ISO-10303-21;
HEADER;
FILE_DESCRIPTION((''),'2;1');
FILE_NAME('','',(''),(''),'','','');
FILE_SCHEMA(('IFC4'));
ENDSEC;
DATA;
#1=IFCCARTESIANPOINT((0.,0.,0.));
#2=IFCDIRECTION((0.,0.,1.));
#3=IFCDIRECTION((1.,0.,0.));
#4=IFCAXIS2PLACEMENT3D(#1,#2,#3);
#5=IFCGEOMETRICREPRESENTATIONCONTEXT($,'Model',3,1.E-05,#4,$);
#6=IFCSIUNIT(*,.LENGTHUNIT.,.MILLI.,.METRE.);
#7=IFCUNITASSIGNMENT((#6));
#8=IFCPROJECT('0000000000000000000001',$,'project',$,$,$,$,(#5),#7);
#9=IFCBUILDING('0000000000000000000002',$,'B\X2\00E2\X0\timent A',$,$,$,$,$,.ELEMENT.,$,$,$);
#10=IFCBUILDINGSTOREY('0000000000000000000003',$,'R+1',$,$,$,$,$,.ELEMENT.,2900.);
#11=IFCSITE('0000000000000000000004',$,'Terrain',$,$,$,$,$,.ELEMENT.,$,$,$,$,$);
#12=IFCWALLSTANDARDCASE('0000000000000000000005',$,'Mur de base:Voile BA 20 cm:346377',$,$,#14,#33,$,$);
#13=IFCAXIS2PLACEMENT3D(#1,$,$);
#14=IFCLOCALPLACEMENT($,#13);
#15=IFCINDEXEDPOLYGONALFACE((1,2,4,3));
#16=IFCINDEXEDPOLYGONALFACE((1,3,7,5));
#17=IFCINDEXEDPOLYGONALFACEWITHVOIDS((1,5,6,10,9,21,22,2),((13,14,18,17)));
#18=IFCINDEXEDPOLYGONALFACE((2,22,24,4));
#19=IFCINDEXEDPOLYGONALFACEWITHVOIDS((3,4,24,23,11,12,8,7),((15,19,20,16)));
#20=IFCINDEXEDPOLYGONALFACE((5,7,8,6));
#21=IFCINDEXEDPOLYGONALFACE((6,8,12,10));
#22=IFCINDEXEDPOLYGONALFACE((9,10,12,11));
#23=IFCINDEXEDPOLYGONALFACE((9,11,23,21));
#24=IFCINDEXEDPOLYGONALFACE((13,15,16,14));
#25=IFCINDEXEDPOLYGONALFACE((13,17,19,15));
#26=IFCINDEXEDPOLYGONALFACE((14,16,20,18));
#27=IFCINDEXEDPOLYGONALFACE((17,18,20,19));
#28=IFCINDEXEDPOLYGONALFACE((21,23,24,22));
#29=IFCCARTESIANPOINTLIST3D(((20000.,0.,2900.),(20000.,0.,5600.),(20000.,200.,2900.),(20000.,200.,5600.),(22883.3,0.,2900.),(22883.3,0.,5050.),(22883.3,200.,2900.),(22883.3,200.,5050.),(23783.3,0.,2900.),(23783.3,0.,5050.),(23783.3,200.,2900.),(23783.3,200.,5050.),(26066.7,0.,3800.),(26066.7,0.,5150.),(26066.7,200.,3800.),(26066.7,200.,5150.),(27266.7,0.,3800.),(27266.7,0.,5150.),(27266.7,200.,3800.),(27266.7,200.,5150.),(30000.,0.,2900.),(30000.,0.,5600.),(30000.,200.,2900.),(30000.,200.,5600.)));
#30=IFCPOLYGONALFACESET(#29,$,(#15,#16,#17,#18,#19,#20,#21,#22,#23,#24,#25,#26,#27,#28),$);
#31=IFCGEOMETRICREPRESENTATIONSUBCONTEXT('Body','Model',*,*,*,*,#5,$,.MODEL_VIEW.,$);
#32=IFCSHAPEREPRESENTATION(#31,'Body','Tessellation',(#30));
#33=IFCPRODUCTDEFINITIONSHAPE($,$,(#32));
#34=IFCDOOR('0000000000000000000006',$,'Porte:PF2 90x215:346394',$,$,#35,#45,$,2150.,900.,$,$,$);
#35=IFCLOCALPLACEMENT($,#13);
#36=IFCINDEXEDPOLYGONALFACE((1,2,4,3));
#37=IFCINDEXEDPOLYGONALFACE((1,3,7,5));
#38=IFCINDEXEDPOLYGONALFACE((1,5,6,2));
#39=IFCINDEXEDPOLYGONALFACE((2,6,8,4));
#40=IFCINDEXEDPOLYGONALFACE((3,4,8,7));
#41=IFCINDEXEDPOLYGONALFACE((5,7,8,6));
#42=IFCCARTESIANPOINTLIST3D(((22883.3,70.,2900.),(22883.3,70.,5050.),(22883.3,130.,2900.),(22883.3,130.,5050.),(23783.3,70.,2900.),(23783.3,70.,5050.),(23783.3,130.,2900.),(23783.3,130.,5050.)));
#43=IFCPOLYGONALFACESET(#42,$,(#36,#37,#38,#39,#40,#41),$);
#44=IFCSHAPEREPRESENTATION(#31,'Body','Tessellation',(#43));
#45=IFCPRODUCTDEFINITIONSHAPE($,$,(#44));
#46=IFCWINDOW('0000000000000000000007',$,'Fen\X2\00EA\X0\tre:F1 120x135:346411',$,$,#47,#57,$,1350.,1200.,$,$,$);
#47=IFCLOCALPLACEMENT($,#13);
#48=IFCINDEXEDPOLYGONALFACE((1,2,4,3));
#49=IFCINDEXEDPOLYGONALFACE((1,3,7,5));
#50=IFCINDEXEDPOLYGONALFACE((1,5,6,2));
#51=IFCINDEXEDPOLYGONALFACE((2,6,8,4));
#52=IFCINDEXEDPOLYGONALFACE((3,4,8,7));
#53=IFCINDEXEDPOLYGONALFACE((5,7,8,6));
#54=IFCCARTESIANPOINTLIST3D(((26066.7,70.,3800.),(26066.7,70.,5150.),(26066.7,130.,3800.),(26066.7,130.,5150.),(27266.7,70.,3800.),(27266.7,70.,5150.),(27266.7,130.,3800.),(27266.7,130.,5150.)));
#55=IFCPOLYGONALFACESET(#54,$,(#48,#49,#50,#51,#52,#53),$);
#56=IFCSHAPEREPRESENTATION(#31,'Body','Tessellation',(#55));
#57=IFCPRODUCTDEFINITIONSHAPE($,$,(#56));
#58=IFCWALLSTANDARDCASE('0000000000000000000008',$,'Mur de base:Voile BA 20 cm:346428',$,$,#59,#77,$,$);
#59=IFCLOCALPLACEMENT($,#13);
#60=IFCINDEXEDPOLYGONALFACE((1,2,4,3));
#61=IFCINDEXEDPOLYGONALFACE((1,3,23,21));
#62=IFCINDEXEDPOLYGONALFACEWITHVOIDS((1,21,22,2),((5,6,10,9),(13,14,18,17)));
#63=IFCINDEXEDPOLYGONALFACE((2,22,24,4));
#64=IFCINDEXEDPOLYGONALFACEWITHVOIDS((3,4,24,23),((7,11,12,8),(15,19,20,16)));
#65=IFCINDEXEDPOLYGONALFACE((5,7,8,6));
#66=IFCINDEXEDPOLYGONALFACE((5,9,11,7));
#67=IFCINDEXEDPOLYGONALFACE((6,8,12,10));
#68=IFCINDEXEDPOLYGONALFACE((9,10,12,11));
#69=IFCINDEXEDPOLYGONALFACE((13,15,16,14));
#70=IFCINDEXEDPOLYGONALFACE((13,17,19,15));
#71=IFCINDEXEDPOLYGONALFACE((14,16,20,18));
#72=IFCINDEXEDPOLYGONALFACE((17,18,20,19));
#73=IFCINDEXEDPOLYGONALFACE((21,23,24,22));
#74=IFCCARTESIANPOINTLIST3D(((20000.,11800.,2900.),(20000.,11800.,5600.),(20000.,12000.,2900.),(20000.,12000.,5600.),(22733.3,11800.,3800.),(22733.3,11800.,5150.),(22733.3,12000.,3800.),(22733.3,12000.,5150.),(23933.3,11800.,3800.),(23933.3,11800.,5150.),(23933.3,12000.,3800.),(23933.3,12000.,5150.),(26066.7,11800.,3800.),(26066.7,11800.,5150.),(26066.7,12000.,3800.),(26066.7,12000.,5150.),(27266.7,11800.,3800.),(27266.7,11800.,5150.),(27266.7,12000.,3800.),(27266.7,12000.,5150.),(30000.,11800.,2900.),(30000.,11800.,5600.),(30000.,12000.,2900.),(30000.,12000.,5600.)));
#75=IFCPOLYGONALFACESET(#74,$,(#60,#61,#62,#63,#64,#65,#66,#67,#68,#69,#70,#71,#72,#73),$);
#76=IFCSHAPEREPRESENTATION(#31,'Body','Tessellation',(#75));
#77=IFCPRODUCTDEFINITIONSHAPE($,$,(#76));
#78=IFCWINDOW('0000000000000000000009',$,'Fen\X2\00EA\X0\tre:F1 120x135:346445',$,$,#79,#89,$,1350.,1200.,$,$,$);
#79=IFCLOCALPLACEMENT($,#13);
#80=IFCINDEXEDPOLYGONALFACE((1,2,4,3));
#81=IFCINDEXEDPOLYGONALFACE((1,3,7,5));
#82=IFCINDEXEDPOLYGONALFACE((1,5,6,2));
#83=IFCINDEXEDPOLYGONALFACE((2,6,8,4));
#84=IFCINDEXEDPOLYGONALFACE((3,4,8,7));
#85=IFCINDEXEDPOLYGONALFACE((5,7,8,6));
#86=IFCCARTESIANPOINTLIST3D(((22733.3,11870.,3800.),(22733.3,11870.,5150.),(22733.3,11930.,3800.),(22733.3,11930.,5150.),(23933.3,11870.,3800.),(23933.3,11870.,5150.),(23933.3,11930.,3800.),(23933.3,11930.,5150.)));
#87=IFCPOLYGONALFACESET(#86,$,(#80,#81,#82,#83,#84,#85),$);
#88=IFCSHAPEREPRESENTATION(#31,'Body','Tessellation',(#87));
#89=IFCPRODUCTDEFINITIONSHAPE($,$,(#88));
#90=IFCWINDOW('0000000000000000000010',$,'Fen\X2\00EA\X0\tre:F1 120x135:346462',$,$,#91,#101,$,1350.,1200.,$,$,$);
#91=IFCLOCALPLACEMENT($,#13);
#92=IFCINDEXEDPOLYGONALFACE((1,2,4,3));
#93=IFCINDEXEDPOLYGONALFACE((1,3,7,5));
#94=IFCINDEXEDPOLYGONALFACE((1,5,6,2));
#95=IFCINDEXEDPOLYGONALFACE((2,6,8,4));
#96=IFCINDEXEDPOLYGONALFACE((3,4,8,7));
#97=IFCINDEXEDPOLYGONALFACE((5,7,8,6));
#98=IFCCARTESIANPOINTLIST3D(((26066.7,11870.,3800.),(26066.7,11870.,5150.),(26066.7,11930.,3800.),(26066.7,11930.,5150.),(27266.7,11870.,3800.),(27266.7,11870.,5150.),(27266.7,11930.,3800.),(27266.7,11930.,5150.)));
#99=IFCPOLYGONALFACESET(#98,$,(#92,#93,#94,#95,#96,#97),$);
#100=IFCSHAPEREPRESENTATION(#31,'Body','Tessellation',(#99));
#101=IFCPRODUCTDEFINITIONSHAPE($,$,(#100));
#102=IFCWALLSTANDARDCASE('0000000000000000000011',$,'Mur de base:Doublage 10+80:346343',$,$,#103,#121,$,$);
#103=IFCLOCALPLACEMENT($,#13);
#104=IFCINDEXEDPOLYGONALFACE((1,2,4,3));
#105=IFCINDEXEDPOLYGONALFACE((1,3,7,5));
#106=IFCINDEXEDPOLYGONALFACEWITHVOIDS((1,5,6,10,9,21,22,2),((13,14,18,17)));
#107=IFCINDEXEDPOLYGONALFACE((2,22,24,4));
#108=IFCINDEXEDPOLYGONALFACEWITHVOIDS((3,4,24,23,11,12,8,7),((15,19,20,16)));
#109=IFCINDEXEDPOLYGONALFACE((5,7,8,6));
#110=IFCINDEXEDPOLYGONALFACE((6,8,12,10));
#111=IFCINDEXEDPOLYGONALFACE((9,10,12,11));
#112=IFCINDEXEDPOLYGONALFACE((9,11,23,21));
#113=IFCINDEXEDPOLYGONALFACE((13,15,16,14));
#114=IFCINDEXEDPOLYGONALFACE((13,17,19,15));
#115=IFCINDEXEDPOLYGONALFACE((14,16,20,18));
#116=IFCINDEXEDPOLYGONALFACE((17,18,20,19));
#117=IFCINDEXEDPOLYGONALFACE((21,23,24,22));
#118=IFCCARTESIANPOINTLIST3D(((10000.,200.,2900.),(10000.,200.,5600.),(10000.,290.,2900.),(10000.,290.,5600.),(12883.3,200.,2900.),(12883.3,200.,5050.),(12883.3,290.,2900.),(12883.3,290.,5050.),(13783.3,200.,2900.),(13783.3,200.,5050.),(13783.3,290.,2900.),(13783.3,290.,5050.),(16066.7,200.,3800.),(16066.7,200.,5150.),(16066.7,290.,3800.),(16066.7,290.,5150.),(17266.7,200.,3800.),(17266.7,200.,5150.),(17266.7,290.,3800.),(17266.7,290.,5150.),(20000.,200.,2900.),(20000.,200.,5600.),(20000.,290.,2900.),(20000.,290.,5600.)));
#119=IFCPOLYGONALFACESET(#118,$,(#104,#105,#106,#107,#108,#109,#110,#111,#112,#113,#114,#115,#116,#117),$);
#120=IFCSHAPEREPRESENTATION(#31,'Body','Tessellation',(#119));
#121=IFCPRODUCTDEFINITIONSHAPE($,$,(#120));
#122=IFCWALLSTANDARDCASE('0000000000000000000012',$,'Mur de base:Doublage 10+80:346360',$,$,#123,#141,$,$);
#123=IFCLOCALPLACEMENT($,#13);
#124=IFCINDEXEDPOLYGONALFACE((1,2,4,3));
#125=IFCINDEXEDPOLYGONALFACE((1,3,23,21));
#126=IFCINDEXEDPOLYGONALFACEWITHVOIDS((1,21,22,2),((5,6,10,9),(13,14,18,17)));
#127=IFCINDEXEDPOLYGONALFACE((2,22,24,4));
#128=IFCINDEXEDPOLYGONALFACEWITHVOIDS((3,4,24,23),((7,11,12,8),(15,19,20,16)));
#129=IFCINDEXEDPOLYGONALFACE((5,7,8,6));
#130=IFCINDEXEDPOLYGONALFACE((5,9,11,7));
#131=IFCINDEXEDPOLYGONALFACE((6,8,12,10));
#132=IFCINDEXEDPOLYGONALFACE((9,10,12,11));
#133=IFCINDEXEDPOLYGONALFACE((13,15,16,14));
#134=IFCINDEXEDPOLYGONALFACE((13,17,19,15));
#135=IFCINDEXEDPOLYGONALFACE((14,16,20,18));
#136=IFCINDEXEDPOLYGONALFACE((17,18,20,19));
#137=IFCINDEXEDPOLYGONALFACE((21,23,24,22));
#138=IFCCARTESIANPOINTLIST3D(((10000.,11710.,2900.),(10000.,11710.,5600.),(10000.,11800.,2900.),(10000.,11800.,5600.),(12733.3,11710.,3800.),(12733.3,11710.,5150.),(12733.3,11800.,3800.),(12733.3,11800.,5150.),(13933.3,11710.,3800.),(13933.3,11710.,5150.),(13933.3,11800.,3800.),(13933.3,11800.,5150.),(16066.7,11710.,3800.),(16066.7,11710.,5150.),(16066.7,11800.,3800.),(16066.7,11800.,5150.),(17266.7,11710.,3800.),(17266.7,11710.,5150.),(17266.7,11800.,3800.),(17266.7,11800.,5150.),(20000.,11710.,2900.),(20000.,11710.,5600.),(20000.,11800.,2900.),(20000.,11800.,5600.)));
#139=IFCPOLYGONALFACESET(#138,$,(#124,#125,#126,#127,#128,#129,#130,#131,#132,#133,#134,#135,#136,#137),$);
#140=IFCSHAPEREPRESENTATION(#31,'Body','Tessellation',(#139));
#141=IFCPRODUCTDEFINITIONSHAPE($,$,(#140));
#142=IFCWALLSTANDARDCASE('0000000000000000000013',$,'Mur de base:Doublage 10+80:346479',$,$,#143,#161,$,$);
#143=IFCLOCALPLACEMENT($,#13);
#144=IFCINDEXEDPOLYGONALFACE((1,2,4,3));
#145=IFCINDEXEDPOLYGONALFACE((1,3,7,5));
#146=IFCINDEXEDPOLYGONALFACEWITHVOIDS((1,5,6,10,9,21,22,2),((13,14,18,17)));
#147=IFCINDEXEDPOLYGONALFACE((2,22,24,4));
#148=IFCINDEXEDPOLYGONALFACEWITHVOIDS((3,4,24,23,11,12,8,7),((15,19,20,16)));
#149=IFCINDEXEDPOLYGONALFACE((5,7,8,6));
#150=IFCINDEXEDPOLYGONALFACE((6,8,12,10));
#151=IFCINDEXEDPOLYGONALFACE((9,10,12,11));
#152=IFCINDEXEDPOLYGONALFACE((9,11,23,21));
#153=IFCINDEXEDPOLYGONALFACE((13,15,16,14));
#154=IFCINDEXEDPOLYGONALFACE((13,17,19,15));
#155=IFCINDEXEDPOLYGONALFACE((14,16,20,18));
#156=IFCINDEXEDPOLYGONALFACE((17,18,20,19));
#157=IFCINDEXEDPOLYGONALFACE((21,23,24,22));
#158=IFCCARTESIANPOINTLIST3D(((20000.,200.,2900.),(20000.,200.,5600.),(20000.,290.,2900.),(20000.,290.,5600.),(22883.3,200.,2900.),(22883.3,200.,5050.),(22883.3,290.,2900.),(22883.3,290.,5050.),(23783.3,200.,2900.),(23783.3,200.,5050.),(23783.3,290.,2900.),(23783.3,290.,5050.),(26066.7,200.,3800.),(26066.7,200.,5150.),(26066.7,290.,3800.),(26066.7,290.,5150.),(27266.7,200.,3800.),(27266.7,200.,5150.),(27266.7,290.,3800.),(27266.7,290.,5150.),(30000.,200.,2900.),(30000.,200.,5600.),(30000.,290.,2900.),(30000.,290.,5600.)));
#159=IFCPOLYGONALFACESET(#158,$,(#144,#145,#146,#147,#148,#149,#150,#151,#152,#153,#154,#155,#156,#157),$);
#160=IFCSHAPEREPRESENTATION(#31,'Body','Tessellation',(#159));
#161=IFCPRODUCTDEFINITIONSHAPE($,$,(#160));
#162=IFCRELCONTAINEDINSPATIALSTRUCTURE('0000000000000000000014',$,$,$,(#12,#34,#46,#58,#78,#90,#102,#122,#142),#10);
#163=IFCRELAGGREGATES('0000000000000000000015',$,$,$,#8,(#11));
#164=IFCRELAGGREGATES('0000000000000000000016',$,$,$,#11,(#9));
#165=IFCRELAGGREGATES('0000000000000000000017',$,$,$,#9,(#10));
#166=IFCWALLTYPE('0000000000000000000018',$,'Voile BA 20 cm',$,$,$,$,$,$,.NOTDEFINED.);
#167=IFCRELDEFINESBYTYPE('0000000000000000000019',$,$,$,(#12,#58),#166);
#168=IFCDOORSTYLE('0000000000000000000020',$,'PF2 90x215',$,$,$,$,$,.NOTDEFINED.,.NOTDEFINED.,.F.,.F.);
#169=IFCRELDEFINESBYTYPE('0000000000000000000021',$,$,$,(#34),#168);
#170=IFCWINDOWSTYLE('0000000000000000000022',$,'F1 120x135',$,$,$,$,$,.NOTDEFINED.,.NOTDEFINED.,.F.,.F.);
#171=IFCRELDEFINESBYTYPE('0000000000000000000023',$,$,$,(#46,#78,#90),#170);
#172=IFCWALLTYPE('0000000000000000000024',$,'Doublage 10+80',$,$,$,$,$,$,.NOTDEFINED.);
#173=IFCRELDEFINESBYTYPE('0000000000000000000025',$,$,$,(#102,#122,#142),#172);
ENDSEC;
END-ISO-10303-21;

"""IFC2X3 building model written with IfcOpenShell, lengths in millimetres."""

from ifc_helpers import new_model, si_unit, frame, frame_2d, origin_with_axes, place, context, subcontext, project, spatial, rectangle, extrude, type_object, element, fill, save


model = new_model("IFC2X3")

# Units and contexts
model_context = context("Model", 3, precision=1e-05, world=origin_with_axes())
body_context = subcontext(model_context, "Body", "Model", "MODEL_VIEW")
ifc_project = project(units=[si_unit("LENGTHUNIT", "METRE", prefix="MILLI")], contexts=[model_context])

# Site, building, storey
site = spatial("IfcSite", under=ifc_project, Name="Terrain", CompositionType="ELEMENT")
building = spatial("IfcBuilding", under=site, Name="Bâtiment A", CompositionType="ELEMENT")
storey = spatial("IfcBuildingStorey", under=building, Name="R+1", CompositionType="ELEMENT", Elevation=2900.0)

# Wall, openings, door, window
wall_type_1 = type_object("IfcWallType", Name="Voile BA 20 cm", PredefinedType="NOTDEFINED")
wall_1_placement = place(None, origin_with_axes())
wall_1 = element("IfcWallStandardCase", 1, at=wall_1_placement, inside=storey, type_object=wall_type_1, Name="Mur de base:Voile BA 20 cm:346377", context=body_context, shape_type="SweptSolid", body=[
    extrude(rectangle(XDim=10000.0, YDim=200.0, at=frame_2d((25000.0, 100.0))), frame((0.0, 0.0, 2900.0), z_axis=(0.0, 0.0, 1.0), x_axis=(1.0, 0.0, 0.0)), (0.0, 0.0, 1.0), 2700.0),
])
opening_1_placement = place(None, origin_with_axes())
opening_1 = element("IfcOpeningElement", 2, at=opening_1_placement, cuts=wall_1, context=body_context, shape_type="SweptSolid", body=[
    extrude(rectangle(XDim=900.0, YDim=320.0, at=frame_2d((23333.3, 100.0))), frame((0.0, 0.0, 2900.0), z_axis=(0.0, 0.0, 1.0), x_axis=(1.0, 0.0, 0.0)), (0.0, 0.0, 1.0), 2150.0),
])
opening_2_placement = place(None, origin_with_axes())
opening_2 = element("IfcOpeningElement", 3, at=opening_2_placement, cuts=wall_1, context=body_context, shape_type="SweptSolid", body=[
    extrude(rectangle(XDim=1200.0, YDim=320.0, at=frame_2d((26666.7, 100.0))), frame((0.0, 0.0, 3800.0), z_axis=(0.0, 0.0, 1.0), x_axis=(1.0, 0.0, 0.0)), (0.0, 0.0, 1.0), 1350.0),
])
door_style = type_object("IfcDoorStyle", Name="PF2 90x215", ConstructionType="NOTDEFINED", OperationType="NOTDEFINED", ParameterTakesPrecedence=False, Sizeable=False)
door_placement = place(None, origin_with_axes())
door = element("IfcDoor", 4, at=door_placement, inside=storey, type_object=door_style, Name="Porte:PF2 90x215:346394", OverallHeight=2150.0, OverallWidth=900.0, context=body_context, shape_type="SweptSolid", body=[
    extrude(rectangle(XDim=900.0, YDim=60.0, at=frame_2d((23333.3, 100.0))), frame((0.0, 0.0, 2900.0), z_axis=(0.0, 0.0, 1.0), x_axis=(1.0, 0.0, 0.0)), (0.0, 0.0, 1.0), 2150.0),
])
fill(opening_1, door)
window_style = type_object("IfcWindowStyle", Name="F1 120x135", ConstructionType="NOTDEFINED", OperationType="NOTDEFINED", ParameterTakesPrecedence=False, Sizeable=False)
window_1_placement = place(None, origin_with_axes())
window_1 = element("IfcWindow", 5, at=window_1_placement, inside=storey, type_object=window_style, Name="Fenêtre:F1 120x135:346411", OverallHeight=1350.0, OverallWidth=1200.0, context=body_context, shape_type="SweptSolid", body=[
    extrude(rectangle(XDim=1200.0, YDim=60.0, at=frame_2d((26666.7, 100.0))), frame((0.0, 0.0, 3800.0), z_axis=(0.0, 0.0, 1.0), x_axis=(1.0, 0.0, 0.0)), (0.0, 0.0, 1.0), 1350.0),
])
fill(opening_2, window_1)

# Wall, openings, windows
wall_2_placement = place(None, origin_with_axes())
wall_2 = element("IfcWallStandardCase", 6, at=wall_2_placement, inside=storey, type_object=wall_type_1, Name="Mur de base:Voile BA 20 cm:346428", context=body_context, shape_type="SweptSolid", body=[
    extrude(rectangle(XDim=10000.0, YDim=200.0, at=frame_2d((25000.0, 11900.0))), frame((0.0, 0.0, 2900.0), z_axis=(0.0, 0.0, 1.0), x_axis=(1.0, 0.0, 0.0)), (0.0, 0.0, 1.0), 2700.0),
])
opening_3_placement = place(None, origin_with_axes())
opening_3 = element("IfcOpeningElement", 7, at=opening_3_placement, cuts=wall_2, context=body_context, shape_type="SweptSolid", body=[
    extrude(rectangle(XDim=1200.0, YDim=320.0, at=frame_2d((23333.3, 11900.0))), frame((0.0, 0.0, 3800.0), z_axis=(0.0, 0.0, 1.0), x_axis=(1.0, 0.0, 0.0)), (0.0, 0.0, 1.0), 1350.0),
])
opening_4_placement = place(None, origin_with_axes())
opening_4 = element("IfcOpeningElement", 8, at=opening_4_placement, cuts=wall_2, context=body_context, shape_type="SweptSolid", body=[
    extrude(rectangle(XDim=1200.0, YDim=320.0, at=frame_2d((26666.7, 11900.0))), frame((0.0, 0.0, 3800.0), z_axis=(0.0, 0.0, 1.0), x_axis=(1.0, 0.0, 0.0)), (0.0, 0.0, 1.0), 1350.0),
])
window_2_placement = place(None, origin_with_axes())
window_2 = element("IfcWindow", 9, at=window_2_placement, inside=storey, type_object=window_style, Name="Fenêtre:F1 120x135:346445", OverallHeight=1350.0, OverallWidth=1200.0, context=body_context, shape_type="SweptSolid", body=[
    extrude(rectangle(XDim=1200.0, YDim=60.0, at=frame_2d((23333.3, 11900.0))), frame((0.0, 0.0, 3800.0), z_axis=(0.0, 0.0, 1.0), x_axis=(1.0, 0.0, 0.0)), (0.0, 0.0, 1.0), 1350.0),
])
fill(opening_3, window_2)
window_3_placement = place(None, origin_with_axes())
window_3 = element("IfcWindow", 10, at=window_3_placement, inside=storey, type_object=window_style, Name="Fenêtre:F1 120x135:346462", OverallHeight=1350.0, OverallWidth=1200.0, context=body_context, shape_type="SweptSolid", body=[
    extrude(rectangle(XDim=1200.0, YDim=60.0, at=frame_2d((26666.7, 11900.0))), frame((0.0, 0.0, 3800.0), z_axis=(0.0, 0.0, 1.0), x_axis=(1.0, 0.0, 0.0)), (0.0, 0.0, 1.0), 1350.0),
])
fill(opening_4, window_3)

# Walls, openings
wall_type_2 = type_object("IfcWallType", Name="Doublage 10+80", PredefinedType="NOTDEFINED")
wall_3_placement = place(None, origin_with_axes())
wall_3 = element("IfcWallStandardCase", 11, at=wall_3_placement, inside=storey, type_object=wall_type_2, Name="Mur de base:Doublage 10+80:346343", context=body_context, shape_type="SweptSolid", body=[
    extrude(rectangle(XDim=10000.0, YDim=90.0, at=frame_2d((15000.0, 245.0))), frame((0.0, 0.0, 2900.0), z_axis=(0.0, 0.0, 1.0), x_axis=(1.0, 0.0, 0.0)), (0.0, 0.0, 1.0), 2700.0),
])
opening_5_placement = place(None, origin_with_axes())
element("IfcOpeningElement", 12, at=opening_5_placement, cuts=wall_3, context=body_context, shape_type="SweptSolid", body=[
    extrude(rectangle(XDim=900.0, YDim=210.0, at=frame_2d((13333.3, 245.0))), frame((0.0, 0.0, 2900.0), z_axis=(0.0, 0.0, 1.0), x_axis=(1.0, 0.0, 0.0)), (0.0, 0.0, 1.0), 2150.0),
])
opening_6_placement = place(None, origin_with_axes())
element("IfcOpeningElement", 13, at=opening_6_placement, cuts=wall_3, context=body_context, shape_type="SweptSolid", body=[
    extrude(rectangle(XDim=1200.0, YDim=210.0, at=frame_2d((16666.7, 245.0))), frame((0.0, 0.0, 3800.0), z_axis=(0.0, 0.0, 1.0), x_axis=(1.0, 0.0, 0.0)), (0.0, 0.0, 1.0), 1350.0),
])
wall_4_placement = place(None, origin_with_axes())
wall_4 = element("IfcWallStandardCase", 14, at=wall_4_placement, inside=storey, type_object=wall_type_2, Name="Mur de base:Doublage 10+80:346360", context=body_context, shape_type="SweptSolid", body=[
    extrude(rectangle(XDim=10000.0, YDim=90.0, at=frame_2d((15000.0, 11755.0))), frame((0.0, 0.0, 2900.0), z_axis=(0.0, 0.0, 1.0), x_axis=(1.0, 0.0, 0.0)), (0.0, 0.0, 1.0), 2700.0),
])
opening_7_placement = place(None, origin_with_axes())
element("IfcOpeningElement", 15, at=opening_7_placement, cuts=wall_4, context=body_context, shape_type="SweptSolid", body=[
    extrude(rectangle(XDim=1200.0, YDim=210.0, at=frame_2d((13333.3, 11755.0))), frame((0.0, 0.0, 3800.0), z_axis=(0.0, 0.0, 1.0), x_axis=(1.0, 0.0, 0.0)), (0.0, 0.0, 1.0), 1350.0),
])
opening_8_placement = place(None, origin_with_axes())
element("IfcOpeningElement", 16, at=opening_8_placement, cuts=wall_4, context=body_context, shape_type="SweptSolid", body=[
    extrude(rectangle(XDim=1200.0, YDim=210.0, at=frame_2d((16666.7, 11755.0))), frame((0.0, 0.0, 3800.0), z_axis=(0.0, 0.0, 1.0), x_axis=(1.0, 0.0, 0.0)), (0.0, 0.0, 1.0), 1350.0),
])
wall_5_placement = place(None, origin_with_axes())
wall_5 = element("IfcWallStandardCase", 17, at=wall_5_placement, inside=storey, type_object=wall_type_2, Name="Mur de base:Doublage 10+80:346479", context=body_context, shape_type="SweptSolid", body=[
    extrude(rectangle(XDim=10000.0, YDim=90.0, at=frame_2d((25000.0, 245.0))), frame((0.0, 0.0, 2900.0), z_axis=(0.0, 0.0, 1.0), x_axis=(1.0, 0.0, 0.0)), (0.0, 0.0, 1.0), 2700.0),
])
opening_9_placement = place(None, origin_with_axes())
element("IfcOpeningElement", 18, at=opening_9_placement, cuts=wall_5, context=body_context, shape_type="SweptSolid", body=[
    extrude(rectangle(XDim=900.0, YDim=210.0, at=frame_2d((23333.3, 245.0))), frame((0.0, 0.0, 2900.0), z_axis=(0.0, 0.0, 1.0), x_axis=(1.0, 0.0, 0.0)), (0.0, 0.0, 1.0), 2150.0),
])
opening_10_placement = place(None, origin_with_axes())
element("IfcOpeningElement", 19, at=opening_10_placement, cuts=wall_5, context=body_context, shape_type="SweptSolid", body=[
    extrude(rectangle(XDim=1200.0, YDim=210.0, at=frame_2d((26666.7, 245.0))), frame((0.0, 0.0, 3800.0), z_axis=(0.0, 0.0, 1.0), x_axis=(1.0, 0.0, 0.0)), (0.0, 0.0, 1.0), 1350.0),
])

save(model, "model.ifc")
